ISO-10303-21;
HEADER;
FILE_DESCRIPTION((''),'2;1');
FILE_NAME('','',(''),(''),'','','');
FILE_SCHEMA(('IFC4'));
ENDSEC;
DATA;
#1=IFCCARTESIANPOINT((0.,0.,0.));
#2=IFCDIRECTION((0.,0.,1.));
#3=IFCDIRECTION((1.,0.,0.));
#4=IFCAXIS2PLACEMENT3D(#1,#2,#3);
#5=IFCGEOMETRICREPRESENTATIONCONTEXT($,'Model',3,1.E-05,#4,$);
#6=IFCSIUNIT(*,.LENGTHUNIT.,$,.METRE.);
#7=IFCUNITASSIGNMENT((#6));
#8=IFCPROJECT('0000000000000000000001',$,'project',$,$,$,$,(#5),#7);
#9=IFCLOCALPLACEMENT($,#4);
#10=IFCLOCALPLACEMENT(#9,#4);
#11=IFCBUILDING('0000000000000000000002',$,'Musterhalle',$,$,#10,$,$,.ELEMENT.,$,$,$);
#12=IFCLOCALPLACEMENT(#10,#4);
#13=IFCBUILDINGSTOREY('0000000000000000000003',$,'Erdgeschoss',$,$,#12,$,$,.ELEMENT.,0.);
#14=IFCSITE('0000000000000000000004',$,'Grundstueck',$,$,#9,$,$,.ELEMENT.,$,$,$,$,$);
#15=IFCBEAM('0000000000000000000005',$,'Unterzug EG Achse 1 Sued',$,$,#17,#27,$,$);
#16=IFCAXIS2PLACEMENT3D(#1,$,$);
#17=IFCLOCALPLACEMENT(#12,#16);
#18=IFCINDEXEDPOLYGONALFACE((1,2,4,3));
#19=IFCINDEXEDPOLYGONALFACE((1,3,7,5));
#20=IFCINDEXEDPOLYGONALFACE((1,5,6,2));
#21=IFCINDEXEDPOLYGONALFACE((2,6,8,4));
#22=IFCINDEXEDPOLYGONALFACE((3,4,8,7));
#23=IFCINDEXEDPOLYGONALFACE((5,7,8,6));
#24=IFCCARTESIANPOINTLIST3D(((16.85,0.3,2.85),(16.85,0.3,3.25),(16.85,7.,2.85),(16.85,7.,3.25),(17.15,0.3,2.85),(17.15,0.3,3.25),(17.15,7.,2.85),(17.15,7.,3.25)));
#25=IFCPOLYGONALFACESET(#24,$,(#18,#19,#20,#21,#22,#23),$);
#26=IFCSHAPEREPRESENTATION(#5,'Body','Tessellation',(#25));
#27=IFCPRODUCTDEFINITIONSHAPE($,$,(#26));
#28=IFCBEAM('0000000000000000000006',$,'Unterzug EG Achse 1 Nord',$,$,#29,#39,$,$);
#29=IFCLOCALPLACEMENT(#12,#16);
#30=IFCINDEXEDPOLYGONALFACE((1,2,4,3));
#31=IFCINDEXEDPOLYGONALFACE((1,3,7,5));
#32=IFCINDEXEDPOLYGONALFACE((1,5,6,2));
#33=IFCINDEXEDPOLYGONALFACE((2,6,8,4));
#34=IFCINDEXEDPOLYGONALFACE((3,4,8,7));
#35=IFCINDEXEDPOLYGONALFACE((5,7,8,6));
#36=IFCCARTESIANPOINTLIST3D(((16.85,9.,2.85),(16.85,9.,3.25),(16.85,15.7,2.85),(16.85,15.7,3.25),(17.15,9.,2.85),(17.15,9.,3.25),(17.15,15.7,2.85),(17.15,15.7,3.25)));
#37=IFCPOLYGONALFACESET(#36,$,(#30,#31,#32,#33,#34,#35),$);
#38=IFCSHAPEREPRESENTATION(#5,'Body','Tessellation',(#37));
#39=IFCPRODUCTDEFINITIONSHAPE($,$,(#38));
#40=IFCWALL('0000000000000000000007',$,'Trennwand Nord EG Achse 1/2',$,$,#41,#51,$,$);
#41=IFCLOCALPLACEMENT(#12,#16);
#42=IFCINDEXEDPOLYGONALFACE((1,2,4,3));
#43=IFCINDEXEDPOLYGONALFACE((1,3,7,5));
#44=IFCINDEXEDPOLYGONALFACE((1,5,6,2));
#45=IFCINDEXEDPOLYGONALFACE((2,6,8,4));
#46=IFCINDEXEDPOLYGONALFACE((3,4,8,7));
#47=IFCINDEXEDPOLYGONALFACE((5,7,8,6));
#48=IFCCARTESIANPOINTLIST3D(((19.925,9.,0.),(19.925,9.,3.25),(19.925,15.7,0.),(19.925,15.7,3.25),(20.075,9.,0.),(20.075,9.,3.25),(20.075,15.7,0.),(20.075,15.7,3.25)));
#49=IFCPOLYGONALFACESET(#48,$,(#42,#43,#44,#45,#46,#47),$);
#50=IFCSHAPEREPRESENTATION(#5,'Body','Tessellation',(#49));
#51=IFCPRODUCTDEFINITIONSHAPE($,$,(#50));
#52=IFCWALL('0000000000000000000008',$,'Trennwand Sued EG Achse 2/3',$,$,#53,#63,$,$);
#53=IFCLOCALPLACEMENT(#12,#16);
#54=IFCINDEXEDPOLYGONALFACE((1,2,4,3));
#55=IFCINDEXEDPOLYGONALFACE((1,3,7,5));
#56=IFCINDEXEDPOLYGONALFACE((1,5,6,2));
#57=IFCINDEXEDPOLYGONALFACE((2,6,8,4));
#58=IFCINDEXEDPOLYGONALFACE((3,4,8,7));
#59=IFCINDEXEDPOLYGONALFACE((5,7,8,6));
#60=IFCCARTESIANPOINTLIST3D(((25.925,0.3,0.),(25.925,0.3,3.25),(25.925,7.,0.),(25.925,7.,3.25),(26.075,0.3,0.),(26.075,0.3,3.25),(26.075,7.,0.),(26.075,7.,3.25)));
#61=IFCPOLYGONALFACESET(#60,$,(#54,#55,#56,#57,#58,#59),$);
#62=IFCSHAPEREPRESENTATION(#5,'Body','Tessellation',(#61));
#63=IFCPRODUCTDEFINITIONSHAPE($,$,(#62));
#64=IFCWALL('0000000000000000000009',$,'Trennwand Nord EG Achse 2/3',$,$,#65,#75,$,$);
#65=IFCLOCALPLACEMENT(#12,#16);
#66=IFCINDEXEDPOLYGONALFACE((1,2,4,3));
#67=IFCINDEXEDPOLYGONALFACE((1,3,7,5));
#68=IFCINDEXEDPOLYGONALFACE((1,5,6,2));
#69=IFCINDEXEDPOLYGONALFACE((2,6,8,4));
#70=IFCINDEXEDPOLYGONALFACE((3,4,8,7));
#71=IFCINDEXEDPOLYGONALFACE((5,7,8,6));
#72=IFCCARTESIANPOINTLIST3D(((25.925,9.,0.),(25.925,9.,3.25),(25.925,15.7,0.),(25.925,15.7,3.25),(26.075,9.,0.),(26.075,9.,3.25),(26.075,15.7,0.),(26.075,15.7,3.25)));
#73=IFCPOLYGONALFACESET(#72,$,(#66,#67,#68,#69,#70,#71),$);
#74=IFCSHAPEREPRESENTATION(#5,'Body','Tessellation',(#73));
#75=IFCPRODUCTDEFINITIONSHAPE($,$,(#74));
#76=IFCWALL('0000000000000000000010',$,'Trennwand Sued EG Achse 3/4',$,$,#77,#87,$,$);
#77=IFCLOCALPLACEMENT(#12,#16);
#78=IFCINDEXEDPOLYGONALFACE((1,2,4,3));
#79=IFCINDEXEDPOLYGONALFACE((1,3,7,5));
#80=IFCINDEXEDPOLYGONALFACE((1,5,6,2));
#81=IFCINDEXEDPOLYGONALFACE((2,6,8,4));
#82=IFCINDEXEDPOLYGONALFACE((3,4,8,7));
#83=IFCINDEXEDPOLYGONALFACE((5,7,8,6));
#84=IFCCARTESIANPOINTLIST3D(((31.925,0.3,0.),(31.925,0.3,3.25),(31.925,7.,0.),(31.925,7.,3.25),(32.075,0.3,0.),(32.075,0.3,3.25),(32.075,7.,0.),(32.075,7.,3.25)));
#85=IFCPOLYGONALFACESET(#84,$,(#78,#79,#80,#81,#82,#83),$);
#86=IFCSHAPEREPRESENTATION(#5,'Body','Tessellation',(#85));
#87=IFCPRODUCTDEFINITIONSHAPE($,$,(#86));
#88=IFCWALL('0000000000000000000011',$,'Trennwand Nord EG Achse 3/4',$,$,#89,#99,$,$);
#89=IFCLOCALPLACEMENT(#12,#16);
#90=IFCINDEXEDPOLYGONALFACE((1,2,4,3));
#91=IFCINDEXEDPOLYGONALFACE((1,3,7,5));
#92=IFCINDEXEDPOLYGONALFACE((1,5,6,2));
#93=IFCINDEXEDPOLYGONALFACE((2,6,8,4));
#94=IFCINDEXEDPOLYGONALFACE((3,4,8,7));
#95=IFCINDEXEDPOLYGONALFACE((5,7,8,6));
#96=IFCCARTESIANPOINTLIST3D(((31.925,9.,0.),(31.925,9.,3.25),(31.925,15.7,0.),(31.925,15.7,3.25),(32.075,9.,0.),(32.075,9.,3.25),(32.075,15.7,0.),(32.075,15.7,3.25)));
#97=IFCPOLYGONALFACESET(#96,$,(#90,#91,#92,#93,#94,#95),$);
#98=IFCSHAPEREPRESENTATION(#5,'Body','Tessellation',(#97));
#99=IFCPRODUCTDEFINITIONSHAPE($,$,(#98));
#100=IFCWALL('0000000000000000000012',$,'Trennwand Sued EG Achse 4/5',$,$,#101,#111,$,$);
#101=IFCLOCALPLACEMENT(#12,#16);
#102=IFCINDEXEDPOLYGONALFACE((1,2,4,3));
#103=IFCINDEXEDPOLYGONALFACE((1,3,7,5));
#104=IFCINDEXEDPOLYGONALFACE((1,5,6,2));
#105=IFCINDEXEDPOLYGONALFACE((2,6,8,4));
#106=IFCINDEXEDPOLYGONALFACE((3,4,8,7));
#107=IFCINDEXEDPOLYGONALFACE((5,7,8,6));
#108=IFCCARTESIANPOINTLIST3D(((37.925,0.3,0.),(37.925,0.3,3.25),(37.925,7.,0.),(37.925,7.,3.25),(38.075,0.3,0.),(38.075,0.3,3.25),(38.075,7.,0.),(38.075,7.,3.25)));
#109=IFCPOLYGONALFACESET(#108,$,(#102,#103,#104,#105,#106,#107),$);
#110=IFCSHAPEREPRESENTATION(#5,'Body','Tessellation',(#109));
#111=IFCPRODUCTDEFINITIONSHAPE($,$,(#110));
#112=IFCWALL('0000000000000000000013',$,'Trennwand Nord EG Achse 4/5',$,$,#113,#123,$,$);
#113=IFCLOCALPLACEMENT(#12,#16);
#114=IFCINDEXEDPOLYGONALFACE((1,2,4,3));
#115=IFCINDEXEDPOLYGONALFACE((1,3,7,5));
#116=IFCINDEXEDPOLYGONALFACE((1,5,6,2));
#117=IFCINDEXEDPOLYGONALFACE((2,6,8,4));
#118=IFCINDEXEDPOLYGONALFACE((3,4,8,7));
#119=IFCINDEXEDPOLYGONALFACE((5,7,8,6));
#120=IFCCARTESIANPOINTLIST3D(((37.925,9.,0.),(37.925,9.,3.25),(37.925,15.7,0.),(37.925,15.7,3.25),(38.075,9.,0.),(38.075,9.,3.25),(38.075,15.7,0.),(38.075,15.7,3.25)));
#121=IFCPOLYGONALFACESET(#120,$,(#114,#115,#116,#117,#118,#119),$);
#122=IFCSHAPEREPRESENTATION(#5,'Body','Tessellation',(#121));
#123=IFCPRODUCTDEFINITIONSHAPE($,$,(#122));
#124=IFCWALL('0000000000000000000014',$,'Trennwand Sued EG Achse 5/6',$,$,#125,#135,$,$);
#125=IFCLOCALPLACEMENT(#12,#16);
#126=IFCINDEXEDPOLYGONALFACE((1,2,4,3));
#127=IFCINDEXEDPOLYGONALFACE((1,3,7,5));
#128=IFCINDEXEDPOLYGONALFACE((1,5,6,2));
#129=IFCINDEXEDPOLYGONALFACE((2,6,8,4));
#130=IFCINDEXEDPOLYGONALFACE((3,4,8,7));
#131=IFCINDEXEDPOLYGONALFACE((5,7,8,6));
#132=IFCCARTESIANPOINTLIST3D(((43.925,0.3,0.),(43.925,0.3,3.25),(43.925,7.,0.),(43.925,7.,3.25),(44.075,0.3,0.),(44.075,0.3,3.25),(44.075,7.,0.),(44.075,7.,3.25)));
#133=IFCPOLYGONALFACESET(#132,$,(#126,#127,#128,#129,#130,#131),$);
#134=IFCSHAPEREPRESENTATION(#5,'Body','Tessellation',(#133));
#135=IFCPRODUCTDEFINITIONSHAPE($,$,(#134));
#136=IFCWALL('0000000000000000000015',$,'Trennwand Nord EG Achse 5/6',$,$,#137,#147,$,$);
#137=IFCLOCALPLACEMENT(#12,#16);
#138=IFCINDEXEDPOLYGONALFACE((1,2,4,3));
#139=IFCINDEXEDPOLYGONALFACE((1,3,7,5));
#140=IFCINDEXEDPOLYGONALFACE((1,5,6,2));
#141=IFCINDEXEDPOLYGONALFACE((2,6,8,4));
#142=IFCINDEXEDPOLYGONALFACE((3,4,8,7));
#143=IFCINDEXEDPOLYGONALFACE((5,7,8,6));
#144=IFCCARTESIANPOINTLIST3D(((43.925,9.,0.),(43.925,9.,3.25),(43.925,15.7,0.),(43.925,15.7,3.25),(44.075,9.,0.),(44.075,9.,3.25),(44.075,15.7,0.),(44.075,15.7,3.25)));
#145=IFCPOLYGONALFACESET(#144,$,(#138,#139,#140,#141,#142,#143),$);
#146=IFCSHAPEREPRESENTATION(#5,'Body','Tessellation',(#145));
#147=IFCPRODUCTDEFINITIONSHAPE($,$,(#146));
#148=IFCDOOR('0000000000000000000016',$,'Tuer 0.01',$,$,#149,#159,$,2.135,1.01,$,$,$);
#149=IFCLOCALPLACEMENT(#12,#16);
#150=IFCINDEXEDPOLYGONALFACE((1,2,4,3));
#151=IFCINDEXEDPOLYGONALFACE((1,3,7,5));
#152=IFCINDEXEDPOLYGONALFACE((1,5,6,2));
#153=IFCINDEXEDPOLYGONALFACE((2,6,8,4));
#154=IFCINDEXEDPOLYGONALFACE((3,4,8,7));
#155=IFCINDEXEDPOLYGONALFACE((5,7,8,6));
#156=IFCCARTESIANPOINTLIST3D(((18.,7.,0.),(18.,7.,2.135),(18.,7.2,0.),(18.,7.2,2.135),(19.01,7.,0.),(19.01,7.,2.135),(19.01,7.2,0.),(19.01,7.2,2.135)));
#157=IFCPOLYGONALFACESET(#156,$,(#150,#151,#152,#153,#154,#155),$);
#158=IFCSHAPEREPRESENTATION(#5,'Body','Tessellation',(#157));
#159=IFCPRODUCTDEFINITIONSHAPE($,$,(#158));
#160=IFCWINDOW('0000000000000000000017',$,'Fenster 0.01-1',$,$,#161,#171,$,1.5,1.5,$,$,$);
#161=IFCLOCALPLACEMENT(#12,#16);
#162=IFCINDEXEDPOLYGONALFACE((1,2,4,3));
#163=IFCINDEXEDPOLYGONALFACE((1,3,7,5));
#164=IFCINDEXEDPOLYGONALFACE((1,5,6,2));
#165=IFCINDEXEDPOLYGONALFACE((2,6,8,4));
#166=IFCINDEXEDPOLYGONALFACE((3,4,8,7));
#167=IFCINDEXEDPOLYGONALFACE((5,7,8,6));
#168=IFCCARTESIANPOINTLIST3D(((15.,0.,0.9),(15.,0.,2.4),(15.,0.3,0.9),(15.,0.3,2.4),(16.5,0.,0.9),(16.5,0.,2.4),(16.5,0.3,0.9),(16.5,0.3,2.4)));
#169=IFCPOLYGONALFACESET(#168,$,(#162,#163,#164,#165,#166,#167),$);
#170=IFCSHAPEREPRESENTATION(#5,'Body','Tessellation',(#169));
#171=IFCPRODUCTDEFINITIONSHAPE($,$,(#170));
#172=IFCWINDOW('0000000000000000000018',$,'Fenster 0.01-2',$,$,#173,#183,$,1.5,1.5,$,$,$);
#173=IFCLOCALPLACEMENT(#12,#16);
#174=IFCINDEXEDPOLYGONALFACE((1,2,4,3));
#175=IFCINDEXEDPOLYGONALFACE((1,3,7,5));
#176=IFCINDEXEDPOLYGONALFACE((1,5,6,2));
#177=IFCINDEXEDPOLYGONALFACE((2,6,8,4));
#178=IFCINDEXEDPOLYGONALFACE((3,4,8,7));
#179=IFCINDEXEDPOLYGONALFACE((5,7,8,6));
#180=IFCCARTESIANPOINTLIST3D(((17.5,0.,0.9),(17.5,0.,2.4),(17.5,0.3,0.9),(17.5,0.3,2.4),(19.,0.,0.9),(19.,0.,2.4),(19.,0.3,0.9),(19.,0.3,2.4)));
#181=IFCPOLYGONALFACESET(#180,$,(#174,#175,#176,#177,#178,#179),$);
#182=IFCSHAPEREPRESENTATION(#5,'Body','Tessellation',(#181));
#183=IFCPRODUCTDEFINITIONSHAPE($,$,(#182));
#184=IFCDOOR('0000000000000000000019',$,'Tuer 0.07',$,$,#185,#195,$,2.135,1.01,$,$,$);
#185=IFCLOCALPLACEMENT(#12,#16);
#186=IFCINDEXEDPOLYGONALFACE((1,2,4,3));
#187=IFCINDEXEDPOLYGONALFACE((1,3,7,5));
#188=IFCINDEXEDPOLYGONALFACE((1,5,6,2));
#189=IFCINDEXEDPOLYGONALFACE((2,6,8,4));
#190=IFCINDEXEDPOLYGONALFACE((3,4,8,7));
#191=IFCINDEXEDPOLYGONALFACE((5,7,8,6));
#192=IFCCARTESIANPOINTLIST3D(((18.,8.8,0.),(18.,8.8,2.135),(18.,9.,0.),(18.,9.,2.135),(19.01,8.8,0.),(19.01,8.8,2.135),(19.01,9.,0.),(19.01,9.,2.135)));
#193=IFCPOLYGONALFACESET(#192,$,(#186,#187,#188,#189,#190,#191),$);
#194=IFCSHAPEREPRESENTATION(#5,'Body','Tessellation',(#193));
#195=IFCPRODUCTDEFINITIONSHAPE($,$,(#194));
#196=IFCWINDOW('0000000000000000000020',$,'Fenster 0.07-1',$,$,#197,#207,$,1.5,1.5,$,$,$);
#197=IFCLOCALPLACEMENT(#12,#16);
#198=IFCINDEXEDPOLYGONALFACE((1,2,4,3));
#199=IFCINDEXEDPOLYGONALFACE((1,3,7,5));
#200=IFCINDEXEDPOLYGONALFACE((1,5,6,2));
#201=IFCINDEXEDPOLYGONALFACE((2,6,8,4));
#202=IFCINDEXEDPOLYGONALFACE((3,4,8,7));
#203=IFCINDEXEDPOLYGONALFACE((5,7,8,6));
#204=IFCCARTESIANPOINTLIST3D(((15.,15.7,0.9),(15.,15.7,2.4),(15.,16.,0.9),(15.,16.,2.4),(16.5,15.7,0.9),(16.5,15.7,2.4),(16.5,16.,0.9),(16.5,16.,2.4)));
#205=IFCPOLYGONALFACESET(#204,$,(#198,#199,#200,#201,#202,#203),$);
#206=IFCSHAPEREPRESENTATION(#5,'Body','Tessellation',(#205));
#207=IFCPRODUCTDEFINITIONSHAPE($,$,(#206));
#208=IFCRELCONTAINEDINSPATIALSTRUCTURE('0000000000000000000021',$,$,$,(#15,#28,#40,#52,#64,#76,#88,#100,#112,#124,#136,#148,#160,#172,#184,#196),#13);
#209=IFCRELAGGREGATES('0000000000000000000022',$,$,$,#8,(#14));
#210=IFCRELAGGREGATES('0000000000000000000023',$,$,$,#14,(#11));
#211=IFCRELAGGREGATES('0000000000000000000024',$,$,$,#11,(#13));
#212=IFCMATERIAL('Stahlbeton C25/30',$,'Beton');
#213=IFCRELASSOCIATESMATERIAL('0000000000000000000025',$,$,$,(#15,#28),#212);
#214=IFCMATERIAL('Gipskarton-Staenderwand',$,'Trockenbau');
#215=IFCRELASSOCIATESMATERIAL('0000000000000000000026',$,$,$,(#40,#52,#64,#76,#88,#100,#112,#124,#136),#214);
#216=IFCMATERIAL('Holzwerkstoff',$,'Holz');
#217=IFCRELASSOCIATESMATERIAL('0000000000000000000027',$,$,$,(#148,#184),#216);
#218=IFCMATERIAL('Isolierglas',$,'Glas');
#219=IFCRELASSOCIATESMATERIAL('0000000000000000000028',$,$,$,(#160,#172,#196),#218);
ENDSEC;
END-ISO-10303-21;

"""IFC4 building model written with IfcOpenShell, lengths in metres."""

from ifc_helpers import new_model, si_unit, frame, origin_with_axes, origin_2d, place, context, project, spatial, rectangle, extrude, material, element, save


model = new_model("IFC4")

# Units and contexts
model_context = context("Model", 3, precision=1e-05, world=origin_with_axes())
ifc_project = project(units=[si_unit("LENGTHUNIT", "METRE")], contexts=[model_context])

# Site, building, storey
site_placement = place(None, origin_with_axes())
site = spatial("IfcSite", under=ifc_project, at=site_placement, Name="Grundstueck", CompositionType="ELEMENT")
building_placement = place(site_placement, origin_with_axes())
building = spatial("IfcBuilding", under=site, at=building_placement, Name="Musterhalle", CompositionType="ELEMENT")
storey_placement = place(building_placement, origin_with_axes())
storey = spatial("IfcBuildingStorey", under=building, at=storey_placement, Name="Erdgeschoss", CompositionType="ELEMENT", Elevation=0.0)

# Beams
ifc_material_1 = material(Name="Stahlbeton C25/30", Category="Beton")
placement = place(storey_placement, origin_with_axes())
element("IfcBeam", 1, at=placement, inside=storey, material=ifc_material_1, Name="Unterzug EG Achse 1 Sued", context=model_context, shape_type="SweptSolid", body=[
    extrude(rectangle(XDim=0.3, YDim=6.7, at=origin_2d()), frame((17.0, 3.65, 2.85), z_axis=(0.0, 0.0, 1.0), x_axis=(1.0, 0.0, 0.0)), (0.0, 0.0, 1.0), 0.4),
])
element("IfcBeam", 2, at=placement, inside=storey, material=ifc_material_1, Name="Unterzug EG Achse 1 Nord", context=model_context, shape_type="SweptSolid", body=[
    extrude(rectangle(XDim=0.3, YDim=6.7, at=origin_2d()), frame((17.0, 12.35, 2.85), z_axis=(0.0, 0.0, 1.0), x_axis=(1.0, 0.0, 0.0)), (0.0, 0.0, 1.0), 0.4),
])

# Walls
ifc_material_2 = material(Name="Gipskarton-Staenderwand", Category="Trockenbau")
element("IfcWall", 3, at=placement, inside=storey, material=ifc_material_2, Name="Trennwand Nord EG Achse 1/2", context=model_context, shape_type="SweptSolid", body=[
    extrude(rectangle(XDim=0.15, YDim=6.7, at=origin_2d()), frame((20.0, 12.35, 0.0), z_axis=(0.0, 0.0, 1.0), x_axis=(1.0, 0.0, 0.0)), (0.0, 0.0, 1.0), 3.25),
])
element("IfcWall", 4, at=placement, inside=storey, material=ifc_material_2, Name="Trennwand Sued EG Achse 2/3", context=model_context, shape_type="SweptSolid", body=[
    extrude(rectangle(XDim=0.15, YDim=6.7, at=origin_2d()), frame((26.0, 3.65, 0.0), z_axis=(0.0, 0.0, 1.0), x_axis=(1.0, 0.0, 0.0)), (0.0, 0.0, 1.0), 3.25),
])
element("IfcWall", 5, at=placement, inside=storey, material=ifc_material_2, Name="Trennwand Nord EG Achse 2/3", context=model_context, shape_type="SweptSolid", body=[
    extrude(rectangle(XDim=0.15, YDim=6.7, at=origin_2d()), frame((26.0, 12.35, 0.0), z_axis=(0.0, 0.0, 1.0), x_axis=(1.0, 0.0, 0.0)), (0.0, 0.0, 1.0), 3.25),
])
element("IfcWall", 6, at=placement, inside=storey, material=ifc_material_2, Name="Trennwand Sued EG Achse 3/4", context=model_context, shape_type="SweptSolid", body=[
    extrude(rectangle(XDim=0.15, YDim=6.7, at=origin_2d()), frame((32.0, 3.65, 0.0), z_axis=(0.0, 0.0, 1.0), x_axis=(1.0, 0.0, 0.0)), (0.0, 0.0, 1.0), 3.25),
])
element("IfcWall", 7, at=placement, inside=storey, material=ifc_material_2, Name="Trennwand Nord EG Achse 3/4", context=model_context, shape_type="SweptSolid", body=[
    extrude(rectangle(XDim=0.15, YDim=6.7, at=origin_2d()), frame((32.0, 12.35, 0.0), z_axis=(0.0, 0.0, 1.0), x_axis=(1.0, 0.0, 0.0)), (0.0, 0.0, 1.0), 3.25),
])
element("IfcWall", 8, at=placement, inside=storey, material=ifc_material_2, Name="Trennwand Sued EG Achse 4/5", context=model_context, shape_type="SweptSolid", body=[
    extrude(rectangle(XDim=0.15, YDim=6.7, at=origin_2d()), frame((38.0, 3.65, 0.0), z_axis=(0.0, 0.0, 1.0), x_axis=(1.0, 0.0, 0.0)), (0.0, 0.0, 1.0), 3.25),
])
element("IfcWall", 9, at=placement, inside=storey, material=ifc_material_2, Name="Trennwand Nord EG Achse 4/5", context=model_context, shape_type="SweptSolid", body=[
    extrude(rectangle(XDim=0.15, YDim=6.7, at=origin_2d()), frame((38.0, 12.35, 0.0), z_axis=(0.0, 0.0, 1.0), x_axis=(1.0, 0.0, 0.0)), (0.0, 0.0, 1.0), 3.25),
])
element("IfcWall", 10, at=placement, inside=storey, material=ifc_material_2, Name="Trennwand Sued EG Achse 5/6", context=model_context, shape_type="SweptSolid", body=[
    extrude(rectangle(XDim=0.15, YDim=6.7, at=origin_2d()), frame((44.0, 3.65, 0.0), z_axis=(0.0, 0.0, 1.0), x_axis=(1.0, 0.0, 0.0)), (0.0, 0.0, 1.0), 3.25),
])
element("IfcWall", 11, at=placement, inside=storey, material=ifc_material_2, Name="Trennwand Nord EG Achse 5/6", context=model_context, shape_type="SweptSolid", body=[
    extrude(rectangle(XDim=0.15, YDim=6.7, at=origin_2d()), frame((44.0, 12.35, 0.0), z_axis=(0.0, 0.0, 1.0), x_axis=(1.0, 0.0, 0.0)), (0.0, 0.0, 1.0), 3.25),
])

# Door
ifc_material_3 = material(Name="Holzwerkstoff", Category="Holz")
element("IfcDoor", 12, at=placement, inside=storey, material=ifc_material_3, Name="Tuer 0.01", OverallHeight=2.135, OverallWidth=1.01, context=model_context, shape_type="SweptSolid", body=[
    extrude(rectangle(XDim=1.01, YDim=0.2, at=origin_2d()), frame((18.505, 7.1, 0.0), z_axis=(0.0, 0.0, 1.0), x_axis=(1.0, 0.0, 0.0)), (0.0, 0.0, 1.0), 2.135),
])

# Windows
ifc_material_4 = material(Name="Isolierglas", Category="Glas")
element("IfcWindow", 13, at=placement, inside=storey, material=ifc_material_4, Name="Fenster 0.01-1", OverallHeight=1.5, OverallWidth=1.5, context=model_context, shape_type="SweptSolid", body=[
    extrude(rectangle(XDim=1.5, YDim=0.3, at=origin_2d()), frame((15.75, 0.15, 0.9), z_axis=(0.0, 0.0, 1.0), x_axis=(1.0, 0.0, 0.0)), (0.0, 0.0, 1.0), 1.5),
])
element("IfcWindow", 14, at=placement, inside=storey, material=ifc_material_4, Name="Fenster 0.01-2", OverallHeight=1.5, OverallWidth=1.5, context=model_context, shape_type="SweptSolid", body=[
    extrude(rectangle(XDim=1.5, YDim=0.3, at=origin_2d()), frame((18.25, 0.15, 0.9), z_axis=(0.0, 0.0, 1.0), x_axis=(1.0, 0.0, 0.0)), (0.0, 0.0, 1.0), 1.5),
])

# Door
element("IfcDoor", 15, at=placement, inside=storey, material=ifc_material_3, Name="Tuer 0.07", OverallHeight=2.135, OverallWidth=1.01, context=model_context, shape_type="SweptSolid", body=[
    extrude(rectangle(XDim=1.01, YDim=0.2, at=origin_2d()), frame((18.505, 8.9, 0.0), z_axis=(0.0, 0.0, 1.0), x_axis=(1.0, 0.0, 0.0)), (0.0, 0.0, 1.0), 2.135),
])

# Window
element("IfcWindow", 16, at=placement, inside=storey, material=ifc_material_4, Name="Fenster 0.07-1", OverallHeight=1.5, OverallWidth=1.5, context=model_context, shape_type="SweptSolid", body=[
    extrude(rectangle(XDim=1.5, YDim=0.3, at=origin_2d()), frame((15.75, 15.85, 0.9), z_axis=(0.0, 0.0, 1.0), x_axis=(1.0, 0.0, 0.0)), (0.0, 0.0, 1.0), 1.5),
])

save(model, "model.ifc")
